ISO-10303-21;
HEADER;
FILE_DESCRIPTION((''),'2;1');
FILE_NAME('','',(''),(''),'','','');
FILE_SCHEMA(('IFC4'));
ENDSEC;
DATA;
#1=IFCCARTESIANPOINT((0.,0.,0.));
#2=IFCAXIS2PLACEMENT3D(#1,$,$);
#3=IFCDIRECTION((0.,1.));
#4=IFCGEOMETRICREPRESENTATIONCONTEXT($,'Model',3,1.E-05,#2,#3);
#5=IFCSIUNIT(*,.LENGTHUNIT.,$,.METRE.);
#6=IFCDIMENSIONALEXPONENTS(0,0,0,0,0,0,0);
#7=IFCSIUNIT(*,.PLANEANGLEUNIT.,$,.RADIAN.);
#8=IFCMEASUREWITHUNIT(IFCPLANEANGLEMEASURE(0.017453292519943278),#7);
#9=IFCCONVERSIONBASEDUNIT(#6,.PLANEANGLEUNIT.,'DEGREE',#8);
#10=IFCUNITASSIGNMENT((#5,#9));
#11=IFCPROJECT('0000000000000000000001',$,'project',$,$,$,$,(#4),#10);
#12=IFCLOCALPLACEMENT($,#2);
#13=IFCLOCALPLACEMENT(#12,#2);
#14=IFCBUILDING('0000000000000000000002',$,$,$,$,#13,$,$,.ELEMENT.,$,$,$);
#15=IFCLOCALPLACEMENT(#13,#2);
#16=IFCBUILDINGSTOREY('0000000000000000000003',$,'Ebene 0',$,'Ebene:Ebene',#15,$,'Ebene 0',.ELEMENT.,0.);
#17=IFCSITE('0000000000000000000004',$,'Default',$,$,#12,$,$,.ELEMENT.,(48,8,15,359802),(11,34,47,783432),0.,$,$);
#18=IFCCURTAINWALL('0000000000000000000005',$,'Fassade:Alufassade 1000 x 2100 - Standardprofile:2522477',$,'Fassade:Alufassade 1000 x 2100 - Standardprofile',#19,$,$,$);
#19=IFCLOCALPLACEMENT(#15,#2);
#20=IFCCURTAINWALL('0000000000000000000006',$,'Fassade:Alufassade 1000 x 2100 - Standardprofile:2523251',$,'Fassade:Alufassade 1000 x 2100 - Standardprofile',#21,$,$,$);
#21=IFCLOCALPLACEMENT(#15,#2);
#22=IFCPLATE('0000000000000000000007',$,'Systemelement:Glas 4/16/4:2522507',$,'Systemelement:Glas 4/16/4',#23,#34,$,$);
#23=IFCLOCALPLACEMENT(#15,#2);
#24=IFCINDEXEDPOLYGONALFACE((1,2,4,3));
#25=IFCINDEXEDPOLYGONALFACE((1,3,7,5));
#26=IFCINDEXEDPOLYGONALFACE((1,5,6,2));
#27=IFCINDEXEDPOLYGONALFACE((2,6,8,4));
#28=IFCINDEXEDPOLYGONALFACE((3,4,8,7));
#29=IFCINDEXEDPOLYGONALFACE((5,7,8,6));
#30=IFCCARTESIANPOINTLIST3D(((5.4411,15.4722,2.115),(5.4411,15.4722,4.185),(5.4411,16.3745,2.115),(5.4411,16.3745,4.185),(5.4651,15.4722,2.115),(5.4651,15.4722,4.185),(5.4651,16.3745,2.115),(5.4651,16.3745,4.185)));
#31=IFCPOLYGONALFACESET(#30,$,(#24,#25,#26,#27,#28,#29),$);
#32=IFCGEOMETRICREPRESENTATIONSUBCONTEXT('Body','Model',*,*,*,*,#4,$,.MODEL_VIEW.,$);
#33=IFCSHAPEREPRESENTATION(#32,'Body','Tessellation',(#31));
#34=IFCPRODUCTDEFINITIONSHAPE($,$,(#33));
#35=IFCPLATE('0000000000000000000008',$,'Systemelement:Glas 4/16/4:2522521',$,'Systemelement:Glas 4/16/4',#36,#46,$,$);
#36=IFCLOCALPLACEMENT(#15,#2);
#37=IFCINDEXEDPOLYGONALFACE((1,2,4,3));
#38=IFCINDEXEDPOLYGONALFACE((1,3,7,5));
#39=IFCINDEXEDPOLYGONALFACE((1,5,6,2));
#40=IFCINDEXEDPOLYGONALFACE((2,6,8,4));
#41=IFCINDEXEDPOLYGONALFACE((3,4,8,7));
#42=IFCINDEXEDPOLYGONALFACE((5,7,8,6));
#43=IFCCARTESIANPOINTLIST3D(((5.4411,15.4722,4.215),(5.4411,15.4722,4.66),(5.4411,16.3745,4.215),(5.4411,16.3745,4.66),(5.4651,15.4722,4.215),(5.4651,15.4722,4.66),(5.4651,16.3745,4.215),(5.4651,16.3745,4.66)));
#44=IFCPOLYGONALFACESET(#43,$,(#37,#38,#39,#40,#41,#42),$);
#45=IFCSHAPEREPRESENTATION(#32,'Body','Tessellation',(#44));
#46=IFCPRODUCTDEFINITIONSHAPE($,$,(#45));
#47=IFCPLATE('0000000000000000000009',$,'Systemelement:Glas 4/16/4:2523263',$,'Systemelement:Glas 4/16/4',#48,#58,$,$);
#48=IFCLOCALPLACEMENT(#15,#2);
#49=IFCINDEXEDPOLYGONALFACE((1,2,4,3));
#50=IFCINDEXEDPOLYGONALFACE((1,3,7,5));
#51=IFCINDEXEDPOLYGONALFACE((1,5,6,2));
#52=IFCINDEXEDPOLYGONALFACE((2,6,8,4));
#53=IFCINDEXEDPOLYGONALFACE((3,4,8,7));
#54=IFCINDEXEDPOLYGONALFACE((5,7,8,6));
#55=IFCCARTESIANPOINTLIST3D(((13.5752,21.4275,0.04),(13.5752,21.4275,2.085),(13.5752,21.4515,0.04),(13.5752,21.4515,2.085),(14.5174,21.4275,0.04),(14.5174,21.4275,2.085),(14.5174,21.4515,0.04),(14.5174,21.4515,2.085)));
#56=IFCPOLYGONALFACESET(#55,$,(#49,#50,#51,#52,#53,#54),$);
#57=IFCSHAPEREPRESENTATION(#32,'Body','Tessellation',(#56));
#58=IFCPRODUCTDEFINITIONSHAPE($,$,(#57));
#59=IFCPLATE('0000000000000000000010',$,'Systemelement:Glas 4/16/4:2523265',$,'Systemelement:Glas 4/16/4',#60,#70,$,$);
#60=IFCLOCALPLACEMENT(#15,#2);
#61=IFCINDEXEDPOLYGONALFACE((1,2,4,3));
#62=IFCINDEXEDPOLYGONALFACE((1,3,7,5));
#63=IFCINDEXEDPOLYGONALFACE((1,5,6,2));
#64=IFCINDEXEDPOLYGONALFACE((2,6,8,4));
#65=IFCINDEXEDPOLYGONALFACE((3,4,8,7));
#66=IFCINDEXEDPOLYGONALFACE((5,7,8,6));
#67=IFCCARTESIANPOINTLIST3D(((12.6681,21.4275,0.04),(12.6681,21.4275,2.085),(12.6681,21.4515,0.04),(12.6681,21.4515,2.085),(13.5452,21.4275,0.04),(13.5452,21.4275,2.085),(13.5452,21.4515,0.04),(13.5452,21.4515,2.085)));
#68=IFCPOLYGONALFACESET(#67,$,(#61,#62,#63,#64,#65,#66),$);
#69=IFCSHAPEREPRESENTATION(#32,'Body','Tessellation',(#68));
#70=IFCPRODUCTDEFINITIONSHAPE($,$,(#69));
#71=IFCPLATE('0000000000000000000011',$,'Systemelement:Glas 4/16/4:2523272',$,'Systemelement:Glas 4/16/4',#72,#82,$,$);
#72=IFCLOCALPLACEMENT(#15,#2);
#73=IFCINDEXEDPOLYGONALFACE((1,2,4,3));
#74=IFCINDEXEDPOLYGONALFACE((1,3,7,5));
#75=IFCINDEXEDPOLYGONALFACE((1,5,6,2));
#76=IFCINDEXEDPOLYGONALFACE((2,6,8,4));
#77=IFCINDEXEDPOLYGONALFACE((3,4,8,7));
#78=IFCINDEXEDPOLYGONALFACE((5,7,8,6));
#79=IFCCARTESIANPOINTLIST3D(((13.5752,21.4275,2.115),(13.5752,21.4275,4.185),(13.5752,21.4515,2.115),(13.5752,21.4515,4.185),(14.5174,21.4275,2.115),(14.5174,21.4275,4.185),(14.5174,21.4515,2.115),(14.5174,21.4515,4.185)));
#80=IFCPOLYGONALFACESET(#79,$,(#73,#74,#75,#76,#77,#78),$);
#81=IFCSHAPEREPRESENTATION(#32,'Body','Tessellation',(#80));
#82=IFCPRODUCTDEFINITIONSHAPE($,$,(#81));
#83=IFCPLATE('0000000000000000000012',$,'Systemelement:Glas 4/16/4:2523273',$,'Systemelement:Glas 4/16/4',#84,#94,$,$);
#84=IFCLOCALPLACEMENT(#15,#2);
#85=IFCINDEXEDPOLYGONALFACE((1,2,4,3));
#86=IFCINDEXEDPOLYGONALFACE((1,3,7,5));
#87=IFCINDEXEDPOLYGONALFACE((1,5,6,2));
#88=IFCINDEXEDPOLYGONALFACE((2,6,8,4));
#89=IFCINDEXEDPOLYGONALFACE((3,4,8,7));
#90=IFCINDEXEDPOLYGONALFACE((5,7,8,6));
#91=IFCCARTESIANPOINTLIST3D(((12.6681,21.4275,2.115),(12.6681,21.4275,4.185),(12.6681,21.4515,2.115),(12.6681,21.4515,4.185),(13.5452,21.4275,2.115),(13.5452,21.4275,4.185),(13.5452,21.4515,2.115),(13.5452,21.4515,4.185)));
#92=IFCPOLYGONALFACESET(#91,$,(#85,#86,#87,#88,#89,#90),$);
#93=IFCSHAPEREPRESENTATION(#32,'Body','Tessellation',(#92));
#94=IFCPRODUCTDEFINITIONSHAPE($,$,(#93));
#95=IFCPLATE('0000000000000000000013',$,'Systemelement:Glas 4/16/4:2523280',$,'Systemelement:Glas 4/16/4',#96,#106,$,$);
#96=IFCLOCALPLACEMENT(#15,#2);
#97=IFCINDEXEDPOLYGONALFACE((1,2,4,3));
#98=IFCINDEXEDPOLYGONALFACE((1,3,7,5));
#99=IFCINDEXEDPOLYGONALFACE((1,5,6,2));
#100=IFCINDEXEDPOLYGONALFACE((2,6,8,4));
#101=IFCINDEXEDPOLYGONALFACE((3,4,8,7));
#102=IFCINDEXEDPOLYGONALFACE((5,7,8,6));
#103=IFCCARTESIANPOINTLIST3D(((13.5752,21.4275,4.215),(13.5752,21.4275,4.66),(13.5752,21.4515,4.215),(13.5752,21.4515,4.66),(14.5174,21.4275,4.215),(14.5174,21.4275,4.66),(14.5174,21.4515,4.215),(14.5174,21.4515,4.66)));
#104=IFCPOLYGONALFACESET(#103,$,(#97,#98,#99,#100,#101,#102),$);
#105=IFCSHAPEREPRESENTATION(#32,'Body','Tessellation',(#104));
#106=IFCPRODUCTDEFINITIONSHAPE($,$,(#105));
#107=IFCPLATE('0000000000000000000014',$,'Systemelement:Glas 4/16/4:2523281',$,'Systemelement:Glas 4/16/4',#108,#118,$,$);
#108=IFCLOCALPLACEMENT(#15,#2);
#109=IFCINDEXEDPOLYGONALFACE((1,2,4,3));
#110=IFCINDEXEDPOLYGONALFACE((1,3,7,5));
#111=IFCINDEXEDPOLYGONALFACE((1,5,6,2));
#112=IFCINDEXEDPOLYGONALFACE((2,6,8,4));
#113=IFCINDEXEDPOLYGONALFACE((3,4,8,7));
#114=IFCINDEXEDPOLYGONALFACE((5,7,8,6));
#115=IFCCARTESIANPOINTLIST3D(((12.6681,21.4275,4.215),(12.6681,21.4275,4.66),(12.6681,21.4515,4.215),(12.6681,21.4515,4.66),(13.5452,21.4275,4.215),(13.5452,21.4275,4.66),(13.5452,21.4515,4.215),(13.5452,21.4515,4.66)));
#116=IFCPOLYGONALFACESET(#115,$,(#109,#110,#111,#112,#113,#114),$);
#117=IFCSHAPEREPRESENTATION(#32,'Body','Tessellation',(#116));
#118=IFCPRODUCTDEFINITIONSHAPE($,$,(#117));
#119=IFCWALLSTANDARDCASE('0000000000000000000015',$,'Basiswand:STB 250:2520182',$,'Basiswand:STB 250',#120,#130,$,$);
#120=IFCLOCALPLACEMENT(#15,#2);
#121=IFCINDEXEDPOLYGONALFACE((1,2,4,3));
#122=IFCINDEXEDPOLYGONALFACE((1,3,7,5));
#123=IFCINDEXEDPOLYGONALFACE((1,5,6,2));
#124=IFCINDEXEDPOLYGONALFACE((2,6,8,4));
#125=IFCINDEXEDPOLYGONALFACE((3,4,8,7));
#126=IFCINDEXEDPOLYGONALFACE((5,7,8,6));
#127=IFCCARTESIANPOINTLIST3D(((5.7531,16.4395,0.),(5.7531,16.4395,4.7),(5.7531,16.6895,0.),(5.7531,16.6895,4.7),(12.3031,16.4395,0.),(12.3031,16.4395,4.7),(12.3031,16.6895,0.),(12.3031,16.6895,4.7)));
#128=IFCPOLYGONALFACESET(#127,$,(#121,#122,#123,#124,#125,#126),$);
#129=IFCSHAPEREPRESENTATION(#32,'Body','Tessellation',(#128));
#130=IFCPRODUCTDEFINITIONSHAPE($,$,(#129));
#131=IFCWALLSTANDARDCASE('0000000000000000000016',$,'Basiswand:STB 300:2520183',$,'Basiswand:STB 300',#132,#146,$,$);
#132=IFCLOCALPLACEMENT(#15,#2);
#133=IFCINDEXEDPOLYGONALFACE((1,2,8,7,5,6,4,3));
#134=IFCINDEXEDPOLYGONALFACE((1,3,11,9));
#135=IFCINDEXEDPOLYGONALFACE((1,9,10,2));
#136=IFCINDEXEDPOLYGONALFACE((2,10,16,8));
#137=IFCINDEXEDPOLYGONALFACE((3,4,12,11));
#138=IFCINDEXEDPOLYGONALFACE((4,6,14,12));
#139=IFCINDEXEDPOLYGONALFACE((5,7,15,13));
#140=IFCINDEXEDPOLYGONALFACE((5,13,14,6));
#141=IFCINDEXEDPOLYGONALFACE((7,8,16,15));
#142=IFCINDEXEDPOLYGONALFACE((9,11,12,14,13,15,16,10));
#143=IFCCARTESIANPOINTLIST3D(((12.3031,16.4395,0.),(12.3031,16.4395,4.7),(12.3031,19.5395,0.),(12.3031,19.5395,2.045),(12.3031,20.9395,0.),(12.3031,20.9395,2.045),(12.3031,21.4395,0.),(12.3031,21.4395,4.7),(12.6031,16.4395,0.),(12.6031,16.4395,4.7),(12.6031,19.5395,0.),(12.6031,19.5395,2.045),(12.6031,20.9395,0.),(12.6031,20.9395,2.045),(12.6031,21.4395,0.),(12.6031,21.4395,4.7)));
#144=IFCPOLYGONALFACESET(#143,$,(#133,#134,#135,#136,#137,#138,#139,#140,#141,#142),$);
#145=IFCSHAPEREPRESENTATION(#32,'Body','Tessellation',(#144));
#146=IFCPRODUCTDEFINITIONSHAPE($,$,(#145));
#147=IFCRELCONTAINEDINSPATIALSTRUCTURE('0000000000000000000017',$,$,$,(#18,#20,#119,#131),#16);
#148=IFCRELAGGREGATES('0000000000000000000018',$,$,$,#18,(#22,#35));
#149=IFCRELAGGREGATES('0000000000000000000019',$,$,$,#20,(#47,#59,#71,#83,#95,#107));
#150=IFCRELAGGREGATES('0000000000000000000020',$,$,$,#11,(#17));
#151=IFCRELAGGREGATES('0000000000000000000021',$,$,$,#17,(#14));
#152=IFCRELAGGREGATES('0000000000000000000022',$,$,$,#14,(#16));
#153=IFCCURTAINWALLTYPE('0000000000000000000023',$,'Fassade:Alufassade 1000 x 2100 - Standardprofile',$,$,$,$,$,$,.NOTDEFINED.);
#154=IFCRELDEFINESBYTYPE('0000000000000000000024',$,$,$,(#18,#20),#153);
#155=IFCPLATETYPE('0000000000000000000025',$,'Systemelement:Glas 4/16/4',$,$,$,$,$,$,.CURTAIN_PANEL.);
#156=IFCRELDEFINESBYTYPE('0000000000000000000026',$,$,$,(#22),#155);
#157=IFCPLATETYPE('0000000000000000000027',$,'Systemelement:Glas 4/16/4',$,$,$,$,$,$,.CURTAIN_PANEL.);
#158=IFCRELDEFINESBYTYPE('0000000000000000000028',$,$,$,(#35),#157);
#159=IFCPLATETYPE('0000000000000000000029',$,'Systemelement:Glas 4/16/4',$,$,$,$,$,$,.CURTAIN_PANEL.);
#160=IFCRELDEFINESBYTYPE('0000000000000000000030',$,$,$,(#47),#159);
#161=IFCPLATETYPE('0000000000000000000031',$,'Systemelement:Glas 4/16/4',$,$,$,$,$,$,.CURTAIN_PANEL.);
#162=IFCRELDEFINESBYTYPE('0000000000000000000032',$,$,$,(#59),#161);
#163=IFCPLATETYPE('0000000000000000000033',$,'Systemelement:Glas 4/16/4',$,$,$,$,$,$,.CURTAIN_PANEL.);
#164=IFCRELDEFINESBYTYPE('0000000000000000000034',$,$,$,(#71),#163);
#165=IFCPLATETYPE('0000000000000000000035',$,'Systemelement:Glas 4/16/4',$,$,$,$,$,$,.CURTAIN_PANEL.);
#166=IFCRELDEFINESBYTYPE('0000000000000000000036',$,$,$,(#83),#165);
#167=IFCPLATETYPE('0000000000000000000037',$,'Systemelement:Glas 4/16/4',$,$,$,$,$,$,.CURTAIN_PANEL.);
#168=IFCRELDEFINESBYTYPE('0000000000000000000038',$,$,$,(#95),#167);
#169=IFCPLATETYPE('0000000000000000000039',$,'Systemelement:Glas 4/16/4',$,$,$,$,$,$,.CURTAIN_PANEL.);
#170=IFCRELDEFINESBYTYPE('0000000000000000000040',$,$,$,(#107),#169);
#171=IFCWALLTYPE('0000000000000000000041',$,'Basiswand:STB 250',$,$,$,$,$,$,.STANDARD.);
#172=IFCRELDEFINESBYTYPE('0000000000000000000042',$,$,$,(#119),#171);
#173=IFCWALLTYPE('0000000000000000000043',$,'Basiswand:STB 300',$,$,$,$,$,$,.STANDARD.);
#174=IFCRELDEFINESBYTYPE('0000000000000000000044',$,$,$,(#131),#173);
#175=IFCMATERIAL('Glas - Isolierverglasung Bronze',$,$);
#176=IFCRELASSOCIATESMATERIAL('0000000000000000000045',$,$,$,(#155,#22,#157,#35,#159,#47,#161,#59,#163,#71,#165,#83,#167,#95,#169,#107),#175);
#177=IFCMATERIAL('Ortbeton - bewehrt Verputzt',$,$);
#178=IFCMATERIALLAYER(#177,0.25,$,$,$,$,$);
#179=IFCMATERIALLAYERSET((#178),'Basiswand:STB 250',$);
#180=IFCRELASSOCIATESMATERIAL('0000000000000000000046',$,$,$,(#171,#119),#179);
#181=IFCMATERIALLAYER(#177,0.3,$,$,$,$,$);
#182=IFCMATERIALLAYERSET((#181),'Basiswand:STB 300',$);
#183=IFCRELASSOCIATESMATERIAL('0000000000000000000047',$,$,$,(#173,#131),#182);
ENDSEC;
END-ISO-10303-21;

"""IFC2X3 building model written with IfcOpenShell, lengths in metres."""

from ifc_helpers import new_model, entity, si_unit, converted_unit, direction, frame, frame_2d, origin, origin_2d_with_axis, place, context, subcontext, project, spatial, polyline, rectangle, extrude, clip, bounded_halfspace, source, transform, mapped, material, layer, layer_set, layer_usage, type_object, type_shapes, element, aggregate, save


model = new_model("IFC2X3")

# Units and contexts
model_context = context("Model", 3, precision=1e-05, world=origin(), true_north=direction((0.0, 1.0)))
body_context = subcontext(model_context, "Body", "Model", "MODEL_VIEW")
ifc_project = project(units=[si_unit("LENGTHUNIT", "METRE"), converted_unit("PLANEANGLEUNIT", "DEGREE", entity("IfcPlaneAngleMeasure", 0.017453292519943278), si_unit("PLANEANGLEUNIT", "RADIAN"), dimensions=[0, 0, 0, 0, 0, 0, 0])], contexts=[model_context])

# Site, building, storey
site_placement = place(None, origin())
site = spatial("IfcSite", under=ifc_project, at=site_placement, Name="Default", CompositionType="ELEMENT", RefLatitude=(48, 8, 15, 359802), RefLongitude=(11, 34, 47, 783432), RefElevation=0.0)
building_placement = place(site_placement, origin())
building = spatial("IfcBuilding", under=site, at=building_placement, CompositionType="ELEMENT")
storey_placement = place(building_placement, origin())
storey = spatial("IfcBuildingStorey", under=building, at=storey_placement, Name="Ebene 0", ObjectType="Ebene:Ebene", LongName="Ebene 0", CompositionType="ELEMENT", Elevation=0.0)

# Curtain wall
curtain_wall_type = type_object("IfcCurtainWallType", Name="Fassade:Alufassade 1000 x 2100 - Standardprofile", PredefinedType="NOTDEFINED")
curtain_wall_1_placement = place(storey_placement, origin())
curtain_wall_1 = element("IfcCurtainWall", 1, at=curtain_wall_1_placement, inside=storey, type_object=curtain_wall_type, Name="Fassade:Alufassade 1000 x 2100 - Standardprofile:2522477", ObjectType="Fassade:Alufassade 1000 x 2100 - Standardprofile")

# Curtain wall
curtain_wall_2_placement = place(storey_placement, origin())
curtain_wall_2 = element("IfcCurtainWall", 2, at=curtain_wall_2_placement, inside=storey, type_object=curtain_wall_type, Name="Fassade:Alufassade 1000 x 2100 - Standardprofile:2523251", ObjectType="Fassade:Alufassade 1000 x 2100 - Standardprofile")

# Plates
ifc_material_1 = material(Name="Glas - Isolierverglasung Bronze")
plate_type_1 = type_object("IfcPlateType", Name="Systemelement:Glas 4/16/4", PredefinedType="CURTAIN_PANEL", material=ifc_material_1)
shared_shape_1 = source(origin(), body_context, "Body", "SweptSolid", [
    extrude(rectangle(XDim=0.024, YDim=0.9023, at=origin_2d_with_axis()), frame((0.0, 0.0, 0.0), z_axis=(0.0, 0.0, 1.0), x_axis=(0.0, 1.0, 0.0)), (0.0, 0.0, 1.0), 2.07),
])
type_shapes(plate_type_1, [shared_shape_1])
plate_1_placement = place(curtain_wall_1_placement, frame((5.4531, 15.9233, 2.115), z_axis=(0.0, 0.0, 1.0), x_axis=(0.0, -1.0, 0.0)))
plate_1 = element("IfcPlate", 3, at=plate_1_placement, type_object=plate_type_1, material=ifc_material_1, Name="Systemelement:Glas 4/16/4:2522507", ObjectType="Systemelement:Glas 4/16/4", context=body_context, shape_type="MappedRepresentation", body=[
    mapped(shared_shape_1, transform((0.0, 0.0, 0.0), scale=1.0)),
])
plate_type_2 = type_object("IfcPlateType", Name="Systemelement:Glas 4/16/4", PredefinedType="CURTAIN_PANEL", material=ifc_material_1)
shared_shape_2 = source(origin(), body_context, "Body", "SweptSolid", [
    extrude(rectangle(XDim=0.024, YDim=0.9023, at=origin_2d_with_axis()), frame((0.0, 0.0, 0.0), z_axis=(0.0, 0.0, 1.0), x_axis=(0.0, 1.0, 0.0)), (0.0, 0.0, 1.0), 0.445),
])
type_shapes(plate_type_2, [shared_shape_2])
plate_2_placement = place(curtain_wall_1_placement, frame((5.4531, 15.9233, 4.215), z_axis=(0.0, 0.0, 1.0), x_axis=(0.0, -1.0, 0.0)))
plate_2 = element("IfcPlate", 4, at=plate_2_placement, type_object=plate_type_2, material=ifc_material_1, Name="Systemelement:Glas 4/16/4:2522521", ObjectType="Systemelement:Glas 4/16/4", context=body_context, shape_type="MappedRepresentation", body=[
    mapped(shared_shape_2, transform((0.0, 0.0, 0.0), scale=1.0)),
])
aggregate(curtain_wall_1, [plate_1, plate_2])
plate_type_3 = type_object("IfcPlateType", Name="Systemelement:Glas 4/16/4", PredefinedType="CURTAIN_PANEL", material=ifc_material_1)
shared_shape_3 = source(origin(), body_context, "Body", "SweptSolid", [
    extrude(rectangle(XDim=0.024, YDim=0.9421, at=origin_2d_with_axis()), frame((0.0, 0.0, 0.0), z_axis=(0.0, 0.0, 1.0), x_axis=(0.0, 1.0, 0.0)), (0.0, 0.0, 1.0), 2.045),
])
type_shapes(plate_type_3, [shared_shape_3])
plate_3_placement = place(curtain_wall_2_placement, frame((14.0463, 21.4395, 0.04), z_axis=(0.0, 0.0, 1.0), x_axis=(-1.0, 0.0, 0.0)))
plate_3 = element("IfcPlate", 5, at=plate_3_placement, type_object=plate_type_3, material=ifc_material_1, Name="Systemelement:Glas 4/16/4:2523263", ObjectType="Systemelement:Glas 4/16/4", context=body_context, shape_type="MappedRepresentation", body=[
    mapped(shared_shape_3, transform((0.0, 0.0, 0.0), scale=1.0)),
])
plate_type_4 = type_object("IfcPlateType", Name="Systemelement:Glas 4/16/4", PredefinedType="CURTAIN_PANEL", material=ifc_material_1)
shared_shape_4 = source(origin(), body_context, "Body", "SweptSolid", [
    extrude(rectangle(XDim=0.024, YDim=0.8771, at=origin_2d_with_axis()), frame((0.0, 0.0, 0.0), z_axis=(0.0, 0.0, 1.0), x_axis=(0.0, 1.0, 0.0)), (0.0, 0.0, 1.0), 2.045),
])
type_shapes(plate_type_4, [shared_shape_4])
plate_4_placement = place(curtain_wall_2_placement, frame((13.1067, 21.4395, 0.04), z_axis=(0.0, 0.0, 1.0), x_axis=(-1.0, 0.0, 0.0)))
plate_4 = element("IfcPlate", 6, at=plate_4_placement, type_object=plate_type_4, material=ifc_material_1, Name="Systemelement:Glas 4/16/4:2523265", ObjectType="Systemelement:Glas 4/16/4", context=body_context, shape_type="MappedRepresentation", body=[
    mapped(shared_shape_4, transform((0.0, 0.0, 0.0), scale=1.0)),
])
plate_type_5 = type_object("IfcPlateType", Name="Systemelement:Glas 4/16/4", PredefinedType="CURTAIN_PANEL", material=ifc_material_1)
shared_shape_5 = source(origin(), body_context, "Body", "SweptSolid", [
    extrude(rectangle(XDim=0.024, YDim=0.9421, at=origin_2d_with_axis()), frame((0.0, 0.0, 0.0), z_axis=(0.0, 0.0, 1.0), x_axis=(0.0, 1.0, 0.0)), (0.0, 0.0, 1.0), 2.07),
])
type_shapes(plate_type_5, [shared_shape_5])
plate_5_placement = place(curtain_wall_2_placement, frame((14.0463, 21.4395, 2.115), z_axis=(0.0, 0.0, 1.0), x_axis=(-1.0, 0.0, 0.0)))
plate_5 = element("IfcPlate", 7, at=plate_5_placement, type_object=plate_type_5, material=ifc_material_1, Name="Systemelement:Glas 4/16/4:2523272", ObjectType="Systemelement:Glas 4/16/4", context=body_context, shape_type="MappedRepresentation", body=[
    mapped(shared_shape_5, transform((0.0, 0.0, 0.0), scale=1.0)),
])
plate_type_6 = type_object("IfcPlateType", Name="Systemelement:Glas 4/16/4", PredefinedType="CURTAIN_PANEL", material=ifc_material_1)
shared_shape_6 = source(origin(), body_context, "Body", "SweptSolid", [
    extrude(rectangle(XDim=0.024, YDim=0.8771, at=origin_2d_with_axis()), frame((0.0, 0.0, 0.0), z_axis=(0.0, 0.0, 1.0), x_axis=(0.0, 1.0, 0.0)), (0.0, 0.0, 1.0), 2.07),
])
type_shapes(plate_type_6, [shared_shape_6])
plate_6_placement = place(curtain_wall_2_placement, frame((13.1067, 21.4395, 2.115), z_axis=(0.0, 0.0, 1.0), x_axis=(-1.0, 0.0, 0.0)))
plate_6 = element("IfcPlate", 8, at=plate_6_placement, type_object=plate_type_6, material=ifc_material_1, Name="Systemelement:Glas 4/16/4:2523273", ObjectType="Systemelement:Glas 4/16/4", context=body_context, shape_type="MappedRepresentation", body=[
    mapped(shared_shape_6, transform((0.0, 0.0, 0.0), scale=1.0)),
])
plate_type_7 = type_object("IfcPlateType", Name="Systemelement:Glas 4/16/4", PredefinedType="CURTAIN_PANEL", material=ifc_material_1)
shared_shape_7 = source(origin(), body_context, "Body", "SweptSolid", [
    extrude(rectangle(XDim=0.024, YDim=0.9421, at=origin_2d_with_axis()), frame((0.0, 0.0, 0.0), z_axis=(0.0, 0.0, 1.0), x_axis=(0.0, 1.0, 0.0)), (0.0, 0.0, 1.0), 0.445),
])
type_shapes(plate_type_7, [shared_shape_7])
plate_7_placement = place(curtain_wall_2_placement, frame((14.0463, 21.4395, 4.215), z_axis=(0.0, 0.0, 1.0), x_axis=(-1.0, 0.0, 0.0)))
plate_7 = element("IfcPlate", 9, at=plate_7_placement, type_object=plate_type_7, material=ifc_material_1, Name="Systemelement:Glas 4/16/4:2523280", ObjectType="Systemelement:Glas 4/16/4", context=body_context, shape_type="MappedRepresentation", body=[
    mapped(shared_shape_7, transform((0.0, 0.0, 0.0), scale=1.0)),
])
plate_type_8 = type_object("IfcPlateType", Name="Systemelement:Glas 4/16/4", PredefinedType="CURTAIN_PANEL", material=ifc_material_1)
shared_shape_8 = source(origin(), body_context, "Body", "SweptSolid", [
    extrude(rectangle(XDim=0.024, YDim=0.8771, at=origin_2d_with_axis()), frame((0.0, 0.0, 0.0), z_axis=(0.0, 0.0, 1.0), x_axis=(0.0, 1.0, 0.0)), (0.0, 0.0, 1.0), 0.445),
])
type_shapes(plate_type_8, [shared_shape_8])
plate_8_placement = place(curtain_wall_2_placement, frame((13.1067, 21.4395, 4.215), z_axis=(0.0, 0.0, 1.0), x_axis=(-1.0, 0.0, 0.0)))
plate_8 = element("IfcPlate", 10, at=plate_8_placement, type_object=plate_type_8, material=ifc_material_1, Name="Systemelement:Glas 4/16/4:2523281", ObjectType="Systemelement:Glas 4/16/4", context=body_context, shape_type="MappedRepresentation", body=[
    mapped(shared_shape_8, transform((0.0, 0.0, 0.0), scale=1.0)),
])
aggregate(curtain_wall_2, [plate_3, plate_4, plate_5, plate_6, plate_7, plate_8])

# Wall
ifc_material_2 = material(Name="Ortbeton - bewehrt Verputzt")
ifc_layer_1 = layer(ifc_material_2, 0.25)
ifc_layer_set_1 = layer_set([ifc_layer_1], Name="Basiswand:STB 250")
ifc_layer_usage_1 = layer_usage(ifc_layer_set_1, "AXIS2", "NEGATIVE", 0.125)
wall_type_1 = type_object("IfcWallType", Name="Basiswand:STB 250", PredefinedType="STANDARD", material=ifc_layer_set_1)
wall_1_placement = place(storey_placement, frame((12.3031, 16.5645, 0.0), z_axis=(0.0, 0.0, 1.0), x_axis=(-1.0, 0.0, 0.0)))
element("IfcWallStandardCase", 11, at=wall_1_placement, inside=storey, type_object=wall_type_1, material=ifc_layer_usage_1, Name="Basiswand:STB 250:2520182", ObjectType="Basiswand:STB 250", context=body_context, shape_type="Clipping", body=[
    clip(extrude(rectangle(XDim=6.55, YDim=0.25, at=frame_2d((3.275, 0.0), x_axis=(-1.0, 0.0))), origin(), (0.0, 0.0, 1.0), 4.7), bounded_halfspace(frame((0.0, -0.125, 4.7), z_axis=(0.0, 0.0, -1.0), x_axis=(0.0, 1.0, 0.0)), True, frame((0.0, -0.125, 4.7)), polyline([(0.0, 0.0), (6.55, 0.0), (6.55, 0.25), (3.6, 0.25), (3.3, 0.25), (0.0, 0.25), (0.0, 0.0)]))),
])

# Wall, opening
ifc_layer_2 = layer(ifc_material_2, 0.3)
ifc_layer_set_2 = layer_set([ifc_layer_2], Name="Basiswand:STB 300")
ifc_layer_usage_2 = layer_usage(ifc_layer_set_2, "AXIS2", "NEGATIVE", 0.15)
wall_type_2 = type_object("IfcWallType", Name="Basiswand:STB 300", PredefinedType="STANDARD", material=ifc_layer_set_2)
wall_2_placement = place(storey_placement, frame((12.4531, 21.4395, 0.0), z_axis=(0.0, 0.0, 1.0), x_axis=(0.0, -1.0, 0.0)))
wall_2 = element("IfcWallStandardCase", 12, at=wall_2_placement, inside=storey, type_object=wall_type_2, material=ifc_layer_usage_2, Name="Basiswand:STB 300:2520183", ObjectType="Basiswand:STB 300", context=body_context, shape_type="Clipping", body=[
    clip(extrude(rectangle(XDim=5.0, YDim=0.3, at=frame_2d((2.5, 0.0), x_axis=(-1.0, 0.0))), origin(), (0.0, 0.0, 1.0), 4.7), bounded_halfspace(frame((0.0, -0.15, 4.7), z_axis=(0.0, 0.0, -1.0), x_axis=(1.0, 0.0, 0.0)), True, frame((0.0, -0.15, 4.7)), polyline([(0.0, 0.0), (0.3, 0.0), (4.75, 0.0), (5.0, 0.0), (5.0, 0.3), (1.15, 0.3), (0.85, 0.3), (0.0, 0.3), (0.0, 0.0)]))),
])
opening_1_placement = place(wall_2_placement, frame((1.9, 0.15, -0.18)))
element("IfcOpeningElement", 13, at=opening_1_placement, cuts=wall_2, ObjectType="Opening", context=body_context, shape_type="SweptSolid", body=[
    extrude(rectangle(XDim=2.225, YDim=1.4, at=frame_2d((1.1125, 0.7), x_axis=(-1.0, 0.0))), frame((0.0, 0.0, 0.0), z_axis=(0.0, -1.0, 0.0), x_axis=(0.0, 0.0, 1.0)), (0.0, 0.0, 1.0), 0.3),
])

save(model, "model.ifc")
